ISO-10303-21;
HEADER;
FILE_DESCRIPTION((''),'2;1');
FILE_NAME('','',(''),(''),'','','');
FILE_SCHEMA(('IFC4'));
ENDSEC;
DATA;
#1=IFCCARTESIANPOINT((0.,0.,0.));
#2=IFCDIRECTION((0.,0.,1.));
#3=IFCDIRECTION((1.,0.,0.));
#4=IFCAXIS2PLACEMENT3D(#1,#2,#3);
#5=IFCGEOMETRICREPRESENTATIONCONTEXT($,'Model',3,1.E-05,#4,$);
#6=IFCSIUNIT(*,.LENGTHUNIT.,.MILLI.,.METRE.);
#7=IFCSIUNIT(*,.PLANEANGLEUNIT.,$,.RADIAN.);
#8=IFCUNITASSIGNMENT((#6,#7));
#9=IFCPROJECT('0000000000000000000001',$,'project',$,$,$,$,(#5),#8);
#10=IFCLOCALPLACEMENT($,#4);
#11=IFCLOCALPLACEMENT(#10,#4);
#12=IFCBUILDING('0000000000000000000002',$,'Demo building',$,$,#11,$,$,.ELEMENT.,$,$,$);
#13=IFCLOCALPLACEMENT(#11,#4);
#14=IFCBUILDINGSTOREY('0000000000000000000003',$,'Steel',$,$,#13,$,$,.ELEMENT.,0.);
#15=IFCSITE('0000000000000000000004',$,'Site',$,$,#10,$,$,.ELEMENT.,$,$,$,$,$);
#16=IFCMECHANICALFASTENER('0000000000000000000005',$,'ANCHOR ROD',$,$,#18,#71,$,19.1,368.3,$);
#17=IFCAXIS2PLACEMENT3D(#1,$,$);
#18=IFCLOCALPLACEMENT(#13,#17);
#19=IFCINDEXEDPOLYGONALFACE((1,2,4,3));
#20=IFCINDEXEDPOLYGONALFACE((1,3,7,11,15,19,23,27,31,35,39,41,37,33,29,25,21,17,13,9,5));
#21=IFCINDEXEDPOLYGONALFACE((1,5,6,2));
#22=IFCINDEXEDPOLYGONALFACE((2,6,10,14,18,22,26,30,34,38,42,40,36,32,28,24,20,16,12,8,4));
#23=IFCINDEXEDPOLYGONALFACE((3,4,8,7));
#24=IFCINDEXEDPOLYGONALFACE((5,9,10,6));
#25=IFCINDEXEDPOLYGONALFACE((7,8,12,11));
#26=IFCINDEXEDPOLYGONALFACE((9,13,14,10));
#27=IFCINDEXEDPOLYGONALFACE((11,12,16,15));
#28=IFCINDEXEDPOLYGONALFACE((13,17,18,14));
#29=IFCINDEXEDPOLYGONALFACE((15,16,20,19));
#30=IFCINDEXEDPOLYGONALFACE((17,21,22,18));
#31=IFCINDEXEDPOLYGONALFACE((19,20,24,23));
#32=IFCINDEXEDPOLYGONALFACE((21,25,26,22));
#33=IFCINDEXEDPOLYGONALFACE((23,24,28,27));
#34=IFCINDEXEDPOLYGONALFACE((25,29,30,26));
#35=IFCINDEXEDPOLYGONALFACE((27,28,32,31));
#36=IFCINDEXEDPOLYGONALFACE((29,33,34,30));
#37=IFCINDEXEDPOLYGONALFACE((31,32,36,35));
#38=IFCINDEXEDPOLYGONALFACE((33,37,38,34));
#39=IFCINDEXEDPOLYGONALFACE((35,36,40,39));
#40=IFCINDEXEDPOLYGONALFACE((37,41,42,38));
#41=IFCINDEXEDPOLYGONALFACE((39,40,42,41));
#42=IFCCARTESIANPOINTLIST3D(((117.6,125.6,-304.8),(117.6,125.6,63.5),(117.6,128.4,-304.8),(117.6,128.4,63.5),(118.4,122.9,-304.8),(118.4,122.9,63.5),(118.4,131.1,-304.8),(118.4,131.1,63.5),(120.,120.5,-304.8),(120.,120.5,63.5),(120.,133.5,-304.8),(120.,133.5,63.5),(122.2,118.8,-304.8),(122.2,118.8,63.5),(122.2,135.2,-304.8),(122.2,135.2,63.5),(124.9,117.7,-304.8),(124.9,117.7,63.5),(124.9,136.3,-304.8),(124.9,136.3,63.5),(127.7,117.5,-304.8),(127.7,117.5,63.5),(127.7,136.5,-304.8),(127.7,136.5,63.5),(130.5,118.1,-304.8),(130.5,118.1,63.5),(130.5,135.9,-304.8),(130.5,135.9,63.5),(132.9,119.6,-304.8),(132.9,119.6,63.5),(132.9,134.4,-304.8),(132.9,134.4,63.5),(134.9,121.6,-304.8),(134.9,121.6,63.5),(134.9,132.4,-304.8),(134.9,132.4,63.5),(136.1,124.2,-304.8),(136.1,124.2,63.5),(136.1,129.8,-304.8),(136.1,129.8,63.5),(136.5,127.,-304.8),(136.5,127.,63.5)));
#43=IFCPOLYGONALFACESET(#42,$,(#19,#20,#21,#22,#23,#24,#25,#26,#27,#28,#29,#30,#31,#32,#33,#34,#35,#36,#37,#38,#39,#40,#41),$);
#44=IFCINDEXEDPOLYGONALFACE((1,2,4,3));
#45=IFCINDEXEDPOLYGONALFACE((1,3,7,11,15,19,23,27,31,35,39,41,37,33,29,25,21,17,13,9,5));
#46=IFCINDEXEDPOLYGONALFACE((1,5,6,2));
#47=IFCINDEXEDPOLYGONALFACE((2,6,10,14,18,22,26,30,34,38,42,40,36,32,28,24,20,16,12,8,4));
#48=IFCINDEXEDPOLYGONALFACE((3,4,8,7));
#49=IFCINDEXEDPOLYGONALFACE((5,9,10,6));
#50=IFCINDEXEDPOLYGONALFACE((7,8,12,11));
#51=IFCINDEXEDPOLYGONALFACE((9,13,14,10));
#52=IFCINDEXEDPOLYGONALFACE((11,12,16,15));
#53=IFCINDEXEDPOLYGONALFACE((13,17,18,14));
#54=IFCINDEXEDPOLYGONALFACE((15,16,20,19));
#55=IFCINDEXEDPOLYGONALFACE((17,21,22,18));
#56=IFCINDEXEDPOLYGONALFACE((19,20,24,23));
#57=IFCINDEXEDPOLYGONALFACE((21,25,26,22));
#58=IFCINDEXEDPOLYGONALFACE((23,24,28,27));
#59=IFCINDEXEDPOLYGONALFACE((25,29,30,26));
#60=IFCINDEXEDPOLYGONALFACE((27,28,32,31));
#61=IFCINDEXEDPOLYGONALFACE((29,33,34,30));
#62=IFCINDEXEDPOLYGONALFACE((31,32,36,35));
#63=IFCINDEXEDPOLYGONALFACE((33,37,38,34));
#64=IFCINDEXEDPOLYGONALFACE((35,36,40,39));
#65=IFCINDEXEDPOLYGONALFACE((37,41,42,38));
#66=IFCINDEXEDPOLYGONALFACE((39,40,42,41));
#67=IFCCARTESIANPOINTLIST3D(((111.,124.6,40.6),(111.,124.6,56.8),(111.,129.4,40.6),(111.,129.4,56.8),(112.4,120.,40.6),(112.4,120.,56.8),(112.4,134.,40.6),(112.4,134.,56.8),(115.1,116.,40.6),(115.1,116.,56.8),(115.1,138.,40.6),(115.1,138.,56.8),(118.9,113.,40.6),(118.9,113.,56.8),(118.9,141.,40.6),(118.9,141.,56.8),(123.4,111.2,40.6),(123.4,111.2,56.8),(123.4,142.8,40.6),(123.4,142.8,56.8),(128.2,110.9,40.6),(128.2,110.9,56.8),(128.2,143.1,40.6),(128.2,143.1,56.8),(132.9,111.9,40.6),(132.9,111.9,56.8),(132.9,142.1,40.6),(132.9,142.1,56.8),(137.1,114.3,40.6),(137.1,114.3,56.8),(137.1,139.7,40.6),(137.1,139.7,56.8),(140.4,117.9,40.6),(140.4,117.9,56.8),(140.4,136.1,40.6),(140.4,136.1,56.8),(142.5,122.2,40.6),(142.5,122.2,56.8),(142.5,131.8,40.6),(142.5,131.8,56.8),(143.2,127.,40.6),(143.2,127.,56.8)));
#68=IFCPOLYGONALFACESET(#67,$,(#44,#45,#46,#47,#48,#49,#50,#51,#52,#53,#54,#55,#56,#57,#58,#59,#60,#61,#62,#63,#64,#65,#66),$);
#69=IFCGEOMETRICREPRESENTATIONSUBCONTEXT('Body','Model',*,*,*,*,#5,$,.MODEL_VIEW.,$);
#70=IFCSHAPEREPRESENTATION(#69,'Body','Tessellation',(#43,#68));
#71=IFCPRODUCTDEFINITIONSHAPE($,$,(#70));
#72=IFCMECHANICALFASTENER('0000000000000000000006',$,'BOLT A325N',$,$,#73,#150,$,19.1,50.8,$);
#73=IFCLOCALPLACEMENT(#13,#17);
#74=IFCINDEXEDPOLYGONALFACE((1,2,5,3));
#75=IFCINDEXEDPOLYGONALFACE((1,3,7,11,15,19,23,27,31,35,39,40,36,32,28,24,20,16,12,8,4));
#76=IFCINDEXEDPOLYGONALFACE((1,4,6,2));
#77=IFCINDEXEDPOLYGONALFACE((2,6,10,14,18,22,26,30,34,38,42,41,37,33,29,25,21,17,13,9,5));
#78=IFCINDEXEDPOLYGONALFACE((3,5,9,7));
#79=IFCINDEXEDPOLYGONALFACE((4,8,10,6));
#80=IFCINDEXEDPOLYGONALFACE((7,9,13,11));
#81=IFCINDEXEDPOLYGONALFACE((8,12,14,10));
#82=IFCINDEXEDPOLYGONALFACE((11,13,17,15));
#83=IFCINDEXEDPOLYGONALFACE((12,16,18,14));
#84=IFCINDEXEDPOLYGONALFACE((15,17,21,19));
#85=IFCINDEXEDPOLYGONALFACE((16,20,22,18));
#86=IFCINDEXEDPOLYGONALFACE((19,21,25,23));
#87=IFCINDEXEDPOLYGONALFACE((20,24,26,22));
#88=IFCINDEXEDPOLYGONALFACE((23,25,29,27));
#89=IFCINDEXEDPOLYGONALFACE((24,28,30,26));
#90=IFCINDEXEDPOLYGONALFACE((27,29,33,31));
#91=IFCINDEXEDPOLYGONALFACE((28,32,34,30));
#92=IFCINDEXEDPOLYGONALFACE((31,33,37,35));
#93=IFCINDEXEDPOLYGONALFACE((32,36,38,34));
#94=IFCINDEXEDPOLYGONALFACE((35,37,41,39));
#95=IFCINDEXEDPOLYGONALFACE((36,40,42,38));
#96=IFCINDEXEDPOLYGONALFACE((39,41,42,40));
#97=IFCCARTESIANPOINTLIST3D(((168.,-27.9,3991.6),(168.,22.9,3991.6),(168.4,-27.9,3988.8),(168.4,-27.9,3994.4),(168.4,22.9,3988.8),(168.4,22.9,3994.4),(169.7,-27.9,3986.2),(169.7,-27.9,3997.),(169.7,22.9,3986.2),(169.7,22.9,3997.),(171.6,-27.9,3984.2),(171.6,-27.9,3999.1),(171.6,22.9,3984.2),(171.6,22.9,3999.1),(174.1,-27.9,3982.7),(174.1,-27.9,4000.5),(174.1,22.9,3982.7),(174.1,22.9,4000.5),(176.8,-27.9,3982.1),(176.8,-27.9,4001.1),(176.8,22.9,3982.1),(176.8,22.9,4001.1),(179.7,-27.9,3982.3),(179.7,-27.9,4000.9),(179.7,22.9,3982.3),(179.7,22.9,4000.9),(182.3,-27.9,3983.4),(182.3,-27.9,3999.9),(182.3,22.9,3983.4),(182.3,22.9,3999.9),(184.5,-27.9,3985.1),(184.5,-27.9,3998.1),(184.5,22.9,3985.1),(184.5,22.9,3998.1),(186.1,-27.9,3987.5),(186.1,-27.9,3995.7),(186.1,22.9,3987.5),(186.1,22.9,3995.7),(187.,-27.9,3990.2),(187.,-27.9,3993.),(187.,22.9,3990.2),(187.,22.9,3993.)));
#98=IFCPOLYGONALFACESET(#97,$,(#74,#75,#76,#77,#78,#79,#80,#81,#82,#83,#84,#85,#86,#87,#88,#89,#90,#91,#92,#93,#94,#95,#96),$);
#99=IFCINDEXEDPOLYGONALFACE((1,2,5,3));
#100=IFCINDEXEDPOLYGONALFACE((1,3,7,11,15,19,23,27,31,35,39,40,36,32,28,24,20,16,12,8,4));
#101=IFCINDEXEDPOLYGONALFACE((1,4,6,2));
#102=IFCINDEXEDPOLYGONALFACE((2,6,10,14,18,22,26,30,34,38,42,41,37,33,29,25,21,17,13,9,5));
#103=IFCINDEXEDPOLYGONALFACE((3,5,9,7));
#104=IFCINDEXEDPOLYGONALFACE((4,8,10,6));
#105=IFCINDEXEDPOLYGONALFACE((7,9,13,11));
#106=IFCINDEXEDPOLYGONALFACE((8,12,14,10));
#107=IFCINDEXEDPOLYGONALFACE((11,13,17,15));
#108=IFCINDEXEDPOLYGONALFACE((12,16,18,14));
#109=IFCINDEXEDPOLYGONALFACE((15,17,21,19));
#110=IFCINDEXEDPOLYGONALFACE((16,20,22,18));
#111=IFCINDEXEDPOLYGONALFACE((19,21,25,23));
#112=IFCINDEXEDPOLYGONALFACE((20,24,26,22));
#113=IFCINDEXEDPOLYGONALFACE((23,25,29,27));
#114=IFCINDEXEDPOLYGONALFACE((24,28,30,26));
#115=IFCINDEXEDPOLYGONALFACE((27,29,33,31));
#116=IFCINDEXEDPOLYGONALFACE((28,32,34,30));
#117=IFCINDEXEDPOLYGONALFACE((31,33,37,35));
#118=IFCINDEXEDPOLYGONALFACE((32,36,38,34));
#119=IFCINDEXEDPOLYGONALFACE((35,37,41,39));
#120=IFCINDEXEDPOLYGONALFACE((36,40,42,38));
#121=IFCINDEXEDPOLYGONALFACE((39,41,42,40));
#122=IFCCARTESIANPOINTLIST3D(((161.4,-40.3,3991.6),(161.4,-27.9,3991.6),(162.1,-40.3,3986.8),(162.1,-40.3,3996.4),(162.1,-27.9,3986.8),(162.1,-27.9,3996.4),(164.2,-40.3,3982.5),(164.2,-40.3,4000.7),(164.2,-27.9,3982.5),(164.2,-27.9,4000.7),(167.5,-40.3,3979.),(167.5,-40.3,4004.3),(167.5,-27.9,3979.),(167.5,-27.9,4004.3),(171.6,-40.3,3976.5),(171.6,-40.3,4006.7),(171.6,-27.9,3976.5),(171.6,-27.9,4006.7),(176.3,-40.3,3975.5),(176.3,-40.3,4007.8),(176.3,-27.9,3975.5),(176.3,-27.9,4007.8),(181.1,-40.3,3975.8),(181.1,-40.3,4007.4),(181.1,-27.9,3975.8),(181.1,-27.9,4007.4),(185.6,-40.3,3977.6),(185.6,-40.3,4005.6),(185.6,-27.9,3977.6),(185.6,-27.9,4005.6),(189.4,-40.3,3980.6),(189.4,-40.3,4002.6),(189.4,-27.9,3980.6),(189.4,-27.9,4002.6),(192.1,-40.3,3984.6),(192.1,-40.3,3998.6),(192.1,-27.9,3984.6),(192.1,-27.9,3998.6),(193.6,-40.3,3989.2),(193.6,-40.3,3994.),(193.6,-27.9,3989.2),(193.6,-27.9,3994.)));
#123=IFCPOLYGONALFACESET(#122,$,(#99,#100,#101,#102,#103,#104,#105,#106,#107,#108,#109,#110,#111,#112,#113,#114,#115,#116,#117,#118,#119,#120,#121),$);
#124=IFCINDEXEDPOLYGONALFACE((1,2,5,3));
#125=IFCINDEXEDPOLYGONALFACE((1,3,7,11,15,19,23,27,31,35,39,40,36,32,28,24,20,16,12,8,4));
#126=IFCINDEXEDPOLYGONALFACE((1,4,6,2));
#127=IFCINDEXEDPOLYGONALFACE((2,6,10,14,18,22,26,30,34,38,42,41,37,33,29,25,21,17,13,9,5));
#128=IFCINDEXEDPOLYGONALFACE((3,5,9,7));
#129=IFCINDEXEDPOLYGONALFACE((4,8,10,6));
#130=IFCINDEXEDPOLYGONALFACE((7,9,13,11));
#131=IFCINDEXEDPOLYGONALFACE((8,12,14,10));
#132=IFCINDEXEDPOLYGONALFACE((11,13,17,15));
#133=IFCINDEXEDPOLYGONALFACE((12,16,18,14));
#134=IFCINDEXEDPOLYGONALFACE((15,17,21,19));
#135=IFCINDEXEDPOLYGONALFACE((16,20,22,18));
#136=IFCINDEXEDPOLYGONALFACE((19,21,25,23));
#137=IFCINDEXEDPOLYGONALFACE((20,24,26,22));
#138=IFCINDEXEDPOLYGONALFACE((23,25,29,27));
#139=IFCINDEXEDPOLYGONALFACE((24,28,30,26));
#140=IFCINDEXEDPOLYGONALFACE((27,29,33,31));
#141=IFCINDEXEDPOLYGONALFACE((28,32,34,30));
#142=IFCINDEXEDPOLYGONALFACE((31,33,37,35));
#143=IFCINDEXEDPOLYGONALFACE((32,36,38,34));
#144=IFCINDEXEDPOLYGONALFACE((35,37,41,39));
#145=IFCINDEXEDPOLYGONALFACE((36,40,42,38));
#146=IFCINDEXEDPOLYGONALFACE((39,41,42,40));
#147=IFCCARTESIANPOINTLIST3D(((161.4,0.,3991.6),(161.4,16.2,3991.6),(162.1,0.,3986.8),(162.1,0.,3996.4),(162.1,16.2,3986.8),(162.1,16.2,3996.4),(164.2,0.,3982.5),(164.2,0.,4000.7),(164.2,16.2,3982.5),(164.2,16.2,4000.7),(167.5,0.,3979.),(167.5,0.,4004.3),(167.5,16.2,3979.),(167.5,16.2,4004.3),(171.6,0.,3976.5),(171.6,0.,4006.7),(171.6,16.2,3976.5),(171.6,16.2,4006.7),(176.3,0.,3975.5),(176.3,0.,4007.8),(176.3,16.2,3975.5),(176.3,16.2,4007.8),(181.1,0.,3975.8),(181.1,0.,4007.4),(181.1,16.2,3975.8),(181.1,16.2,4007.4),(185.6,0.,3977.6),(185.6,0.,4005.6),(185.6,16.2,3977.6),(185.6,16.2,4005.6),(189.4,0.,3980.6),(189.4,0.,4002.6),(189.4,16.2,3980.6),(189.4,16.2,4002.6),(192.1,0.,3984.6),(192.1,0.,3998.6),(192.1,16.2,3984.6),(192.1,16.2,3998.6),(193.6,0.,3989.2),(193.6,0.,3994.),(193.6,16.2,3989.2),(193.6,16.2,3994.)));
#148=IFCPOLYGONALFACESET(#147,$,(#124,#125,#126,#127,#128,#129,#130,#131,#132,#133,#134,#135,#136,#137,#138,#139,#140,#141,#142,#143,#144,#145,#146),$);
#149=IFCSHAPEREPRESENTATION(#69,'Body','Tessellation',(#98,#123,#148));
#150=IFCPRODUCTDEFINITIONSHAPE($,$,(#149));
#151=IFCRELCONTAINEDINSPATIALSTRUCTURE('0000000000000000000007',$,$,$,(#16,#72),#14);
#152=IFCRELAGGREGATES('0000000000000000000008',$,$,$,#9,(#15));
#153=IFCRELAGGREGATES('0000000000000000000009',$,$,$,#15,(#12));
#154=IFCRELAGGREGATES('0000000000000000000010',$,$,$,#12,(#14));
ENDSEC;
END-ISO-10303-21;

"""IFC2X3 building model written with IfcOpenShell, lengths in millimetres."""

from ifc_helpers import new_model, si_unit, frame, origin, origin_with_axes, origin_2d, place, context, subcontext, project, spatial, circle, extrude, element, save


model = new_model("IFC2X3")

# Units and contexts
model_context = context("Model", 3, precision=1e-05, world=origin_with_axes())
body_context = subcontext(model_context, "Body", "Model", "MODEL_VIEW")
ifc_project = project(units=[si_unit("LENGTHUNIT", "METRE", prefix="MILLI"), si_unit("PLANEANGLEUNIT", "RADIAN")], contexts=[model_context])

# Site, building, storey
site_placement = place(None, origin_with_axes())
site = spatial("IfcSite", under=ifc_project, at=site_placement, Name="Site", CompositionType="ELEMENT")
building_placement = place(site_placement, origin_with_axes())
building = spatial("IfcBuilding", under=site, at=building_placement, Name="Demo building", CompositionType="ELEMENT")
placement = place(building_placement, origin_with_axes())
storey = spatial("IfcBuildingStorey", under=building, at=placement, Name="Steel", CompositionType="ELEMENT", Elevation=0.0)

# Mechanical fasteners
for number, where, z_axis, x_axis, name in (
    (1, (127.0, 127.0, -304.8), (0.0, 0.0, 1.0), (1.0, 0.0, 0.0), "ANCHOR ROD"),
):
    element("IfcMechanicalFastener", number, at=place(placement, frame(where, z_axis=z_axis, x_axis=x_axis)), inside=storey, Name=name, NominalDiameter=19.1, NominalLength=368.3, context=body_context, shape_type="SweptSolid", body=[
        extrude(circle(Radius=9.5, at=origin_2d()), origin(), (0.0, 0.0, 1.0), 368.3),
        extrude(circle(Radius=16.2, at=origin_2d()), frame((0.0, 0.0, 345.4)), (0.0, 0.0, 1.0), 16.2),
    ])
for number, where, z_axis, x_axis, name in (
    (2, (177.5, -27.9, 3991.6), (0.0, 1.0, 0.0), (-1.0, 0.0, 0.0), "BOLT A325N"),
):
    element("IfcMechanicalFastener", number, at=place(placement, frame(where, z_axis=z_axis, x_axis=x_axis)), inside=storey, Name=name, NominalDiameter=19.1, NominalLength=50.8, context=body_context, shape_type="SweptSolid", body=[
        extrude(circle(Radius=9.5, at=origin_2d()), origin(), (0.0, 0.0, 1.0), 50.8),
        extrude(circle(Radius=16.2, at=origin_2d()), frame((0.0, 0.0, -12.4)), (0.0, 0.0, 1.0), 12.4),
        extrude(circle(Radius=16.2, at=origin_2d()), frame((0.0, 0.0, 27.9)), (0.0, 0.0, 1.0), 16.2),
    ])

save(model, "model.ifc")
